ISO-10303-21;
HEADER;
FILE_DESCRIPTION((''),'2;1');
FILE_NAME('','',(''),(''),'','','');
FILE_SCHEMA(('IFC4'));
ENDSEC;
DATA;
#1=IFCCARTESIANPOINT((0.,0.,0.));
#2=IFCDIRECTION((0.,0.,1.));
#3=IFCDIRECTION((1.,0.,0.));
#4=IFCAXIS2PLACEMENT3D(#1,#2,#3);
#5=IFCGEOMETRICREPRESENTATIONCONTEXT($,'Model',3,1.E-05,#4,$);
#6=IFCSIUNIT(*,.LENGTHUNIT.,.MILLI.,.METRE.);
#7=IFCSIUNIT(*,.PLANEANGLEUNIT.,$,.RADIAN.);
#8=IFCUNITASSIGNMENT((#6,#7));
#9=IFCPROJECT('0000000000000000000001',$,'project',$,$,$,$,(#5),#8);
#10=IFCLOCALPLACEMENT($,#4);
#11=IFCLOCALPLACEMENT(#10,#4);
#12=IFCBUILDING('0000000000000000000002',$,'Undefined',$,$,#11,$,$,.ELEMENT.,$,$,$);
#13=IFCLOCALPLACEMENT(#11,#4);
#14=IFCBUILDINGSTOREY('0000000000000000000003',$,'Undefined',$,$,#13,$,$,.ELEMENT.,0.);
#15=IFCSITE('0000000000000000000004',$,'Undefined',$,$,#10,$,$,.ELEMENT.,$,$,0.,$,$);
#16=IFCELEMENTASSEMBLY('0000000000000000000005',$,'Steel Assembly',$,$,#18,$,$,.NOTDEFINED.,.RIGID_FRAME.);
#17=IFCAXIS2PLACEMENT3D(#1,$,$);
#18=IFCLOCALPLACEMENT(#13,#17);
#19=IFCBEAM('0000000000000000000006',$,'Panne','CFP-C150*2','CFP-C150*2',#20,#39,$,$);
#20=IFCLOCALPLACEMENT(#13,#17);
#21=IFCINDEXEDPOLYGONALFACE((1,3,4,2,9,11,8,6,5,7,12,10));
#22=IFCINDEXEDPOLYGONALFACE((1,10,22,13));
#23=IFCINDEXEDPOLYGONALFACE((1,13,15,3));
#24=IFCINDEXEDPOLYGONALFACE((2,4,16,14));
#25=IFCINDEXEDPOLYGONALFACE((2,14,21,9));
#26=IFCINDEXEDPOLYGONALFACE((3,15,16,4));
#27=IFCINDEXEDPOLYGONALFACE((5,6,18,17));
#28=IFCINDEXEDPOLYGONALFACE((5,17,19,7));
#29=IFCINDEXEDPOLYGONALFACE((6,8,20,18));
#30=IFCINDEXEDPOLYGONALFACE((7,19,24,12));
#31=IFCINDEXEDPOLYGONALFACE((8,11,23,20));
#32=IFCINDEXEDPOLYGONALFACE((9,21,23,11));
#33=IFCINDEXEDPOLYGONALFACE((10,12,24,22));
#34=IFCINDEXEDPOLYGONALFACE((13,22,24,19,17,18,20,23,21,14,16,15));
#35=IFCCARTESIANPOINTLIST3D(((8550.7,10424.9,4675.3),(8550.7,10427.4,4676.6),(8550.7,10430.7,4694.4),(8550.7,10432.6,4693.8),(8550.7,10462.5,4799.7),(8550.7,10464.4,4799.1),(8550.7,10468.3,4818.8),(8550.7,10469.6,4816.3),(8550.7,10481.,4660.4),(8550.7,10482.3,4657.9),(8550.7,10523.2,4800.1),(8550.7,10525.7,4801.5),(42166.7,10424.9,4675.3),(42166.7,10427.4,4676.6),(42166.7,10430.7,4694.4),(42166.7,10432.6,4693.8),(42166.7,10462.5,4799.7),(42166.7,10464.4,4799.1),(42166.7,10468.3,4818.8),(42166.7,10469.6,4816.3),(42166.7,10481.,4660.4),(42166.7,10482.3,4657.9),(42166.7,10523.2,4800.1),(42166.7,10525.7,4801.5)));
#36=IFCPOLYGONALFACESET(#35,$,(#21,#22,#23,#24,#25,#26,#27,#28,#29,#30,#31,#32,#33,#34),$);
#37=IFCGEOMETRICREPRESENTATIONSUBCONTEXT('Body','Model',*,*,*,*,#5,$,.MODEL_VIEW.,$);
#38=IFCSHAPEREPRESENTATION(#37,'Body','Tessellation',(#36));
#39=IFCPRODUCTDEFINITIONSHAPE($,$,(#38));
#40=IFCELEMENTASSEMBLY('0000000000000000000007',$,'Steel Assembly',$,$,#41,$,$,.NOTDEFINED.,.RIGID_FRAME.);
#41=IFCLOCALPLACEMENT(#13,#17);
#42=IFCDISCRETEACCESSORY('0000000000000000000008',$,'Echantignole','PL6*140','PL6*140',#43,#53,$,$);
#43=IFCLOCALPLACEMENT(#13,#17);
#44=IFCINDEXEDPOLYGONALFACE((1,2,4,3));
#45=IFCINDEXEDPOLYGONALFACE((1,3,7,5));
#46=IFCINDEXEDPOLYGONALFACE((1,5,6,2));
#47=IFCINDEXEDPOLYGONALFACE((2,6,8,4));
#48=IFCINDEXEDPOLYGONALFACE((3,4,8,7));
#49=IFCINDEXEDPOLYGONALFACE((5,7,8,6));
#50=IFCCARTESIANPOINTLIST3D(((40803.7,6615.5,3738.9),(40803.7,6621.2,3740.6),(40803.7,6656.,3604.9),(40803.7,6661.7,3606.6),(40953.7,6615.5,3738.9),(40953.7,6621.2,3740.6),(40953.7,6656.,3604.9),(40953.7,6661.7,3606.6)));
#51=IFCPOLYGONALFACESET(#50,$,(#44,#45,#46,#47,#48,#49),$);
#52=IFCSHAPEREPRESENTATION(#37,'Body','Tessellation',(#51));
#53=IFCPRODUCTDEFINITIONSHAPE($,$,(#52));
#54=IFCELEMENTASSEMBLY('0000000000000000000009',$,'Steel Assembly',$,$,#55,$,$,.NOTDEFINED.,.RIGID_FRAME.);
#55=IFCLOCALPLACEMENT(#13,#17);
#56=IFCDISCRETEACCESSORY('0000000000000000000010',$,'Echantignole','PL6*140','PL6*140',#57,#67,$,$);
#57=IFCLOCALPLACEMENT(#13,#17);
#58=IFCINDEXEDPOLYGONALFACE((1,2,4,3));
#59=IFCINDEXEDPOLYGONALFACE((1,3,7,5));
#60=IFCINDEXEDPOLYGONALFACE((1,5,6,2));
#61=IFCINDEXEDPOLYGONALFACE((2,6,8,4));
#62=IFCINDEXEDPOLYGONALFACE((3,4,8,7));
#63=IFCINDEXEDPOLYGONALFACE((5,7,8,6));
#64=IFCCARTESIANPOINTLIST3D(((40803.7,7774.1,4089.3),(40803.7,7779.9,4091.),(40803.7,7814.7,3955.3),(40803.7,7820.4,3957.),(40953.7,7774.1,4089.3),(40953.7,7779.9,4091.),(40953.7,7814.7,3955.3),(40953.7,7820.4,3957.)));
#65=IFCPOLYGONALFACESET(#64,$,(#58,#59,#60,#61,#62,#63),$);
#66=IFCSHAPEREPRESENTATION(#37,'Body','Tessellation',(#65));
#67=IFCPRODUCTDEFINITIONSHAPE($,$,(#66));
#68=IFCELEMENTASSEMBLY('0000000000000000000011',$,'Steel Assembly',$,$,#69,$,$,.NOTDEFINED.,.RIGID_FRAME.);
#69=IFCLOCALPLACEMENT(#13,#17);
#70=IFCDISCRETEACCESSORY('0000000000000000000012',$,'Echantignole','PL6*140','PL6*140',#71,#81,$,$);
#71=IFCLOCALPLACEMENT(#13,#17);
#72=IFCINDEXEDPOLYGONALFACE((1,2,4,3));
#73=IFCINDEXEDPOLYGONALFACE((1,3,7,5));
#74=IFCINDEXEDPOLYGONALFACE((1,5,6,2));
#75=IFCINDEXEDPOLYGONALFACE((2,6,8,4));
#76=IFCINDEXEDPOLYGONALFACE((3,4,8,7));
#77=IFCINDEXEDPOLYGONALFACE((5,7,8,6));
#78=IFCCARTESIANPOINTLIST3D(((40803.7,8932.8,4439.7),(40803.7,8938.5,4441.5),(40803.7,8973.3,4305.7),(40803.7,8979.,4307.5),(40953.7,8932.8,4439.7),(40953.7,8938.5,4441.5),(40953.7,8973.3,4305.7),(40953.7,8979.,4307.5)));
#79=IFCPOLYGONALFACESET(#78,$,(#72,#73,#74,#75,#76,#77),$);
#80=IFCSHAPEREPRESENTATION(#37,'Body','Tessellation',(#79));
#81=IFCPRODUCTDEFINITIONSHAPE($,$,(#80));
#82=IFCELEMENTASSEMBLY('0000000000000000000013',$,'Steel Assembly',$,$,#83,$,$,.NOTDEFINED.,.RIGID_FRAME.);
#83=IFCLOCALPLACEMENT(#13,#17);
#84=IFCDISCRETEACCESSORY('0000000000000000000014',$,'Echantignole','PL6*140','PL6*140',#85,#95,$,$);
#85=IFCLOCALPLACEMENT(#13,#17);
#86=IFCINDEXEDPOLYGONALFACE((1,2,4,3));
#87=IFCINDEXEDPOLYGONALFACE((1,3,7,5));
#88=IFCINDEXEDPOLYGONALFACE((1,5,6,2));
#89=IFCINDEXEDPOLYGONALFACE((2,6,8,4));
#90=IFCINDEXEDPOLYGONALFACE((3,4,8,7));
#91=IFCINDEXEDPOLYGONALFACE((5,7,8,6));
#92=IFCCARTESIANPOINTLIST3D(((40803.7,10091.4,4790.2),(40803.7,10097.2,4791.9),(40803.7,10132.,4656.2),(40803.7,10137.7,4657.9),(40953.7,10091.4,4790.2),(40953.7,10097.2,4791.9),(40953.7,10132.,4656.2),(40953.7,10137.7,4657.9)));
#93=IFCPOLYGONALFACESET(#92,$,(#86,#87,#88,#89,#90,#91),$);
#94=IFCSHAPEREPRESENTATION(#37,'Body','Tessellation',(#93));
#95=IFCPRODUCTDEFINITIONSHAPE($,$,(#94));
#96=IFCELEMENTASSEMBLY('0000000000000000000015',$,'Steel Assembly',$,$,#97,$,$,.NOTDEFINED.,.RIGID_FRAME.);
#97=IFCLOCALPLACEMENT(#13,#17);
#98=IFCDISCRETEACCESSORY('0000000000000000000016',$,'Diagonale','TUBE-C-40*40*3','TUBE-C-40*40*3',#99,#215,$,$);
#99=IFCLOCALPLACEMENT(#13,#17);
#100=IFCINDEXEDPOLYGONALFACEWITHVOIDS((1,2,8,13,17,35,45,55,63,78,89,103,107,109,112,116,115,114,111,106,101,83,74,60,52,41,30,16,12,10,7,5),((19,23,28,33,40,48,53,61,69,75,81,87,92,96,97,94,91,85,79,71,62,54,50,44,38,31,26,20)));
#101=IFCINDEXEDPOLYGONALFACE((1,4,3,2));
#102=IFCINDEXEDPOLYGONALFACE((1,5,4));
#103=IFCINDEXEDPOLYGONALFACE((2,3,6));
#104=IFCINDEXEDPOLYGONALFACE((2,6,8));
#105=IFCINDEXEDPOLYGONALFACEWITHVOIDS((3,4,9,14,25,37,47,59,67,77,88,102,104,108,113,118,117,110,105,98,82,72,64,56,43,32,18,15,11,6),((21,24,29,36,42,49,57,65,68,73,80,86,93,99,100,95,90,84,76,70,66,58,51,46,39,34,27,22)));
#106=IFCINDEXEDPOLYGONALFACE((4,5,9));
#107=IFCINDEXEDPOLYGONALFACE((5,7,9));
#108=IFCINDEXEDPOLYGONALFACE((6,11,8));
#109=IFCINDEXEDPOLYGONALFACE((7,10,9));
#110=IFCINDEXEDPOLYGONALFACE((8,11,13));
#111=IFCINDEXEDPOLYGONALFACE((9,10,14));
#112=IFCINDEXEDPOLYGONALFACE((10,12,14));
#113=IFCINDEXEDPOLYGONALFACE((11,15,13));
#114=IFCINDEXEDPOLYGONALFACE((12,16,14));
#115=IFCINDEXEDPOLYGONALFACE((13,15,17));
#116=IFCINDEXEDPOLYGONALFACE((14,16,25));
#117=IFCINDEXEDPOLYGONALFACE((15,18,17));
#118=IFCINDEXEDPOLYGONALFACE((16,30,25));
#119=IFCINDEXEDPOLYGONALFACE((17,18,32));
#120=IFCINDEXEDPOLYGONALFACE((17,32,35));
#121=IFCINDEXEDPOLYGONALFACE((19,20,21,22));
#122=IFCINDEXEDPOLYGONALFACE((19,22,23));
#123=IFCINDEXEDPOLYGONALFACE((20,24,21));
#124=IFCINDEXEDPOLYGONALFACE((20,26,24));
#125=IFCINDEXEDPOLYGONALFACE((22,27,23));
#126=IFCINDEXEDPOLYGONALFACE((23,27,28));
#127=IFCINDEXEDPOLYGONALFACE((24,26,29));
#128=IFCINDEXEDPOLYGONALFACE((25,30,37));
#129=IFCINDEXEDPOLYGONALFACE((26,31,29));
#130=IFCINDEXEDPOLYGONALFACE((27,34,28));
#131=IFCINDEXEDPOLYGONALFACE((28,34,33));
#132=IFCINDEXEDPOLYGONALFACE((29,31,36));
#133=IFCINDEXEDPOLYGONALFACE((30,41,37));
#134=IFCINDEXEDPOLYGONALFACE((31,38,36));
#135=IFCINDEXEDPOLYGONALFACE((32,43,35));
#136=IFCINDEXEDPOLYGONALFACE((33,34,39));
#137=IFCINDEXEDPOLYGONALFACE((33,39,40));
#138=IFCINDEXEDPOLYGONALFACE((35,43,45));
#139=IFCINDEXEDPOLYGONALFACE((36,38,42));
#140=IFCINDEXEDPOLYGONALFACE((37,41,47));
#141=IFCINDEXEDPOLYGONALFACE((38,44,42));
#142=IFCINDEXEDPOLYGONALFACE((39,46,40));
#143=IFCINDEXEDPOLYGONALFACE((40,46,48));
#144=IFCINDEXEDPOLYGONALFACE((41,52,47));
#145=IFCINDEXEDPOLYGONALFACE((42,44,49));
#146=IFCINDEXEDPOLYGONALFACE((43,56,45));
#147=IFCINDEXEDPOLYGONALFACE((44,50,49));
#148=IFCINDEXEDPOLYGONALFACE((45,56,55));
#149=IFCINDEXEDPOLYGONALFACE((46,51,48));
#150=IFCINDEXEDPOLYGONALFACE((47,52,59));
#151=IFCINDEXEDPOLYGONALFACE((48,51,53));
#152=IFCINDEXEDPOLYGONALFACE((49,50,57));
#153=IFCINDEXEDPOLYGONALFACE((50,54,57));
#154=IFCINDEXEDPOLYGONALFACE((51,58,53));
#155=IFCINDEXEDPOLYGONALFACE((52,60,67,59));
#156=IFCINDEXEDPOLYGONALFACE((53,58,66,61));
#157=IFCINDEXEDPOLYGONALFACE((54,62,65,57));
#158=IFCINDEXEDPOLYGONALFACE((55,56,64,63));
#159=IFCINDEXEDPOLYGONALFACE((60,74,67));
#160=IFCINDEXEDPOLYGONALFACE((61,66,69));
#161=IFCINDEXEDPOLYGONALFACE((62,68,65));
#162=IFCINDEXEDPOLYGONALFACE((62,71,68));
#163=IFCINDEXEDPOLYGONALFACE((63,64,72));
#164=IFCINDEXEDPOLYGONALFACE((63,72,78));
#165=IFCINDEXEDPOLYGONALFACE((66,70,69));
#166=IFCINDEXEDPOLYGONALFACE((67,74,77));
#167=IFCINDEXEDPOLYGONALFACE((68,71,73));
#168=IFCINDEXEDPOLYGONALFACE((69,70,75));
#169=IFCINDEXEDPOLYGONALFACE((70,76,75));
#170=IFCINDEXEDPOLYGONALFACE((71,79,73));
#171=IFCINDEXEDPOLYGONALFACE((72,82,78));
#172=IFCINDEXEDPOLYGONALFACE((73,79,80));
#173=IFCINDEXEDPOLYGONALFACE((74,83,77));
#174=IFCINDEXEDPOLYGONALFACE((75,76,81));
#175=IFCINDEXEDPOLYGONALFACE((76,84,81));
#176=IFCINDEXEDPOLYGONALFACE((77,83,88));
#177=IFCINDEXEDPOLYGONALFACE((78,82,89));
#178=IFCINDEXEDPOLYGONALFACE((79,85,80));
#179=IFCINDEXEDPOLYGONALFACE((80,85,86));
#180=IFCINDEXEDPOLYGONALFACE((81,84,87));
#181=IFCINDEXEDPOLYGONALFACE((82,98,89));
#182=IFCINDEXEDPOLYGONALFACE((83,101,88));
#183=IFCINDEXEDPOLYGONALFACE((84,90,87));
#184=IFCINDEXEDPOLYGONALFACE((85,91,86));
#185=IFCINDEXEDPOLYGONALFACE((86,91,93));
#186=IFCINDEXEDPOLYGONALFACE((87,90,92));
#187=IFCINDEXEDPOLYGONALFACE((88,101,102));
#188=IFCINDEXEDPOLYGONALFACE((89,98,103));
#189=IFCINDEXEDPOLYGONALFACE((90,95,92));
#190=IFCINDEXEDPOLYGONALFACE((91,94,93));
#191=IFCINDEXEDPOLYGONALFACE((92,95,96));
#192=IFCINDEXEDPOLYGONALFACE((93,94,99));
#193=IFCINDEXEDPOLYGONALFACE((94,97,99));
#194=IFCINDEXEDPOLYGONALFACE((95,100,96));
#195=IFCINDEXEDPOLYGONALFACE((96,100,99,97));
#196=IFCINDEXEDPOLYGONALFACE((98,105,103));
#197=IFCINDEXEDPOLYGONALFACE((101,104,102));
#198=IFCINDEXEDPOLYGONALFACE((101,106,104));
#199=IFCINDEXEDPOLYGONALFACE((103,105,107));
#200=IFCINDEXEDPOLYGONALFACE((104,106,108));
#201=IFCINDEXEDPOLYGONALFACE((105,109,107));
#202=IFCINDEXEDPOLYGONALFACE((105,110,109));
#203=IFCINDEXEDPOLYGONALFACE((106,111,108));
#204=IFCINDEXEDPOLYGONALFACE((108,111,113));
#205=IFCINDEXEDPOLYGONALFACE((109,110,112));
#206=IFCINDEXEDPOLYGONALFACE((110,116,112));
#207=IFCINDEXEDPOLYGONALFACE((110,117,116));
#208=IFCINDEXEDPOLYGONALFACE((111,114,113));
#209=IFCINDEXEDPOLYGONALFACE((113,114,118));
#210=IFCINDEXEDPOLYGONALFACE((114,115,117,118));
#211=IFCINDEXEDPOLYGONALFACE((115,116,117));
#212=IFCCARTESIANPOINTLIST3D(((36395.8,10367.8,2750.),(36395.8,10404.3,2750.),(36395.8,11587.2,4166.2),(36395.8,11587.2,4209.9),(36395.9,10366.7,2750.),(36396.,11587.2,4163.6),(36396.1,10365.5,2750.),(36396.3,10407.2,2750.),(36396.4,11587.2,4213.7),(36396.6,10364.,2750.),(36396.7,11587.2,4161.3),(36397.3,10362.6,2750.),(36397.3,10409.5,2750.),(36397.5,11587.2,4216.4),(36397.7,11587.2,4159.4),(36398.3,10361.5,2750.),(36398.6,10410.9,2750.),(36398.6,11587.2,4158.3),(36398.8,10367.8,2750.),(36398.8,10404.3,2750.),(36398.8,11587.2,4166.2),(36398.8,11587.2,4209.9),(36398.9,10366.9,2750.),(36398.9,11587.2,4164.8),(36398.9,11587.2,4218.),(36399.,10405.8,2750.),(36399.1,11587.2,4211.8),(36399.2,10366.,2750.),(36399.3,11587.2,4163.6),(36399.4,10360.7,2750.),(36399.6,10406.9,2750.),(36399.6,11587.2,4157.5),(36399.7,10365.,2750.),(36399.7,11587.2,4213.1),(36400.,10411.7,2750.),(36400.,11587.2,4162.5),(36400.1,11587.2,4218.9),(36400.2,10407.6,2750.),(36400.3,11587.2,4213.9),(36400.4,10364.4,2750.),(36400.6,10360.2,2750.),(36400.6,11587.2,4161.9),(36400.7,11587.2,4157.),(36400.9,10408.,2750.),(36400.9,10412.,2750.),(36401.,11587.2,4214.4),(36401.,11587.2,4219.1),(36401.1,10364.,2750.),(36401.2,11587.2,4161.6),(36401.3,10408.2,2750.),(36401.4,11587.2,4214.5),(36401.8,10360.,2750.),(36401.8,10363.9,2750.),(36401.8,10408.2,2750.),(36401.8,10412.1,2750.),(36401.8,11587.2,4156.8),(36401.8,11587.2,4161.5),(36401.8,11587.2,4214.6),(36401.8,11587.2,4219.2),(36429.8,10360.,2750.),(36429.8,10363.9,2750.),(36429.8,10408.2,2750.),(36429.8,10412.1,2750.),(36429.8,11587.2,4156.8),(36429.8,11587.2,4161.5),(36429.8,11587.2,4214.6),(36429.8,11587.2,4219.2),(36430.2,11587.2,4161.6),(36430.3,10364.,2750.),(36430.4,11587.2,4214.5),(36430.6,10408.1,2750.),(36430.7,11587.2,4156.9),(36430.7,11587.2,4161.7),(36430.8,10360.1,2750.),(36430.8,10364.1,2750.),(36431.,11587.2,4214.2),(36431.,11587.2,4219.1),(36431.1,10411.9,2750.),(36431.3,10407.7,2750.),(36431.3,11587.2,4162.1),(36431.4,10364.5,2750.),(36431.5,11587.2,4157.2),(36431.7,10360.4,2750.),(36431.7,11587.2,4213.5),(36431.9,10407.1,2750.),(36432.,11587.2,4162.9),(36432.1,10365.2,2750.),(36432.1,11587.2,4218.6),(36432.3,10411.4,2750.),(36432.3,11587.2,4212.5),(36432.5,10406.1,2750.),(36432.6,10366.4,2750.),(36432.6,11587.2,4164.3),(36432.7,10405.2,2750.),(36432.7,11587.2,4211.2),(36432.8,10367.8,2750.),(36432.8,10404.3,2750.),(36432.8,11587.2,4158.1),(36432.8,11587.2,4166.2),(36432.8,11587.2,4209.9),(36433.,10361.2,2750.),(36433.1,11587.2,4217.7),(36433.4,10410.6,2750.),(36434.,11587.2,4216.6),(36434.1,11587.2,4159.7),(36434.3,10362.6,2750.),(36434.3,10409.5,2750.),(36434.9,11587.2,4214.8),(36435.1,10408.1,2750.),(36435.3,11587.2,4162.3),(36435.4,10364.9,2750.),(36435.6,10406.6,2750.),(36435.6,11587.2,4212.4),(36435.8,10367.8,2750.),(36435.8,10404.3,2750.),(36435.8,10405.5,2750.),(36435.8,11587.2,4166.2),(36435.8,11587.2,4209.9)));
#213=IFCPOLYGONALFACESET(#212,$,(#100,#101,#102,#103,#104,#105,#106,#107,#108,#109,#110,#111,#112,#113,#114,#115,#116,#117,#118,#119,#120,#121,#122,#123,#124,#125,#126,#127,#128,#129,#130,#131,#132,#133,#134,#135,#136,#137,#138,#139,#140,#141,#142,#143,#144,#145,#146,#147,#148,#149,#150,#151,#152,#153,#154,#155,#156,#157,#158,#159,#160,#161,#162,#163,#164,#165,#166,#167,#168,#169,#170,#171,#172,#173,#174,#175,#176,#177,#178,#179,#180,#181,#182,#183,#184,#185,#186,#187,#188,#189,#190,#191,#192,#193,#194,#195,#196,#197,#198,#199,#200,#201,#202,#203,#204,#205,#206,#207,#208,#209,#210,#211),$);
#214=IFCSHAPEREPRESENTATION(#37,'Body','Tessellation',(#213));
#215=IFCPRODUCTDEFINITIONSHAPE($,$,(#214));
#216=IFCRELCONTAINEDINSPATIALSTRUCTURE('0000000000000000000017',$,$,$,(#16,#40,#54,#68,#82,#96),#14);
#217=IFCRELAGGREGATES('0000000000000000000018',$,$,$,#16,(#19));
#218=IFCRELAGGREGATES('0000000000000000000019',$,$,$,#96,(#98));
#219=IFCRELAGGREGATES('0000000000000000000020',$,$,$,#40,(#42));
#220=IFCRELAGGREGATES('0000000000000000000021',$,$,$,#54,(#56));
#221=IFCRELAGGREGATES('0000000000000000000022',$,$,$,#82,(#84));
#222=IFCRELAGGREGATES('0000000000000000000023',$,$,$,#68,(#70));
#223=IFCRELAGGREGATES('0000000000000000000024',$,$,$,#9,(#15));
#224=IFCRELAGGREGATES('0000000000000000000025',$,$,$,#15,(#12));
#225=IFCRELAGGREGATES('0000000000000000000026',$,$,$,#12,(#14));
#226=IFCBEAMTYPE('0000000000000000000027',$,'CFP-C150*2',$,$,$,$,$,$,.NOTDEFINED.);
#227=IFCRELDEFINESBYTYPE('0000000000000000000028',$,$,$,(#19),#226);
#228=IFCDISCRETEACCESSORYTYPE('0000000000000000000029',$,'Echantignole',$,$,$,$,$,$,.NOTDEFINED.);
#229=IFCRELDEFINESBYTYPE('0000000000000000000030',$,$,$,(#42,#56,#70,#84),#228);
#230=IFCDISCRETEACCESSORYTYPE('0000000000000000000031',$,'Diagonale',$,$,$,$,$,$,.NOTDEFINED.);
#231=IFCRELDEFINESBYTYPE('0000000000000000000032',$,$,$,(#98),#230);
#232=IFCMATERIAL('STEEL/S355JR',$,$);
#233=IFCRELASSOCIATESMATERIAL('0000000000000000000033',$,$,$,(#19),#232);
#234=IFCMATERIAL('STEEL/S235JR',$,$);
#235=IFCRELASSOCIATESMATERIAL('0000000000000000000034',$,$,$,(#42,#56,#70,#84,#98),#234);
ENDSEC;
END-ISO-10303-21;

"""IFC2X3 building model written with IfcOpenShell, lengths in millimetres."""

from ifc_helpers import new_model, si_unit, frame, origin_with_axes, origin_2d_with_axis, place, context, subcontext, project, spatial, polyline, hollow_rectangle, c_section, outline, extrude, clip, halfspace, material, type_object, element, aggregate, save


model = new_model("IFC2X3")

# Units and contexts
model_context = context("Model", 3, precision=1e-05, world=origin_with_axes())
body_context = subcontext(model_context, "Body", "Model", "MODEL_VIEW")
ifc_project = project(units=[si_unit("LENGTHUNIT", "METRE", prefix="MILLI"), si_unit("PLANEANGLEUNIT", "RADIAN")], contexts=[model_context])

# Site, building, storey
site_placement = place(None, origin_with_axes())
site = spatial("IfcSite", under=ifc_project, at=site_placement, Name="Undefined", CompositionType="ELEMENT", RefElevation=0.0)
building_placement = place(site_placement, origin_with_axes())
building = spatial("IfcBuilding", under=site, at=building_placement, Name="Undefined", CompositionType="ELEMENT")
storey_placement = place(building_placement, origin_with_axes())
storey = spatial("IfcBuildingStorey", under=building, at=storey_placement, Name="Undefined", CompositionType="ELEMENT", Elevation=0.0)

# Element assembly, beam
assembly_1_placement = place(storey_placement, origin_with_axes())
assembly_1 = element("IfcElementAssembly", 1, at=assembly_1_placement, inside=storey, Name="Steel Assembly", AssemblyPlace="NOTDEFINED", PredefinedType="RIGID_FRAME")
ifc_material_1 = material(Name="STEEL/S355JR")
beam_type = type_object("IfcBeamType", Name="CFP-C150*2", PredefinedType="NOTDEFINED")
beam_placement = place(assembly_1_placement, frame((42166.7, 10475.3, 4738.4), z_axis=(0.0, -0.289497, -0.957179), x_axis=(-1.0, 0.0, 0.0)))
beam = element("IfcBeam", 2, at=beam_placement, type_object=beam_type, material=ifc_material_1, Name="Panne", Description="CFP-C150*2", ObjectType="CFP-C150*2", context=body_context, shape_type="SweptSolid", body=[
    extrude(c_section(Depth=150.0, Width=60.0, WallThickness=2.0, Girth=20.0, at=origin_2d_with_axis()), frame((33616.0, 0.0, 0.0), z_axis=(-1.0, 0.0, 0.0), x_axis=(0.0, -1.0, 0.0)), (0.0, 0.0, 1.0), 33616.0),
])
aggregate(assembly_1, [beam])

# Element assemblies, discrete accessories
assembly_2_placement = place(storey_placement, origin_with_axes())
assembly_2 = element("IfcElementAssembly", 3, at=assembly_2_placement, inside=storey, Name="Steel Assembly", AssemblyPlace="NOTDEFINED", PredefinedType="RIGID_FRAME")
ifc_material_2 = material(Name="STEEL/S235JR")
discrete_accessory_type_1 = type_object("IfcDiscreteAccessoryType", Name="Echantignole")
discrete_accessory_1_placement = place(assembly_2_placement, frame((40803.7, 6638.6, 3672.7), z_axis=(0.0, -0.957179, -0.289497), x_axis=(1.0, 0.0, 0.0)))
discrete_accessory_1 = element("IfcDiscreteAccessory", 4, at=discrete_accessory_1_placement, type_object=discrete_accessory_type_1, material=ifc_material_2, Name="Echantignole", Description="PL6*140", ObjectType="PL6*140", context=body_context, shape_type="SweptSolid", body=[
    extrude(outline(polyline([(150.0, 70.0), (150.0, -70.0), (0.0, -70.0), (0.0, 70.0), (150.0, 70.0)])), frame((0.0, 0.0, -3.0), z_axis=(0.0, 0.0, 1.0), x_axis=(1.0, 0.0, 0.0)), (0.0, 0.0, 1.0), 6.0),
])
assembly_3_placement = place(storey_placement, origin_with_axes())
assembly_3 = element("IfcElementAssembly", 5, at=assembly_3_placement, inside=storey, Name="Steel Assembly", AssemblyPlace="NOTDEFINED", PredefinedType="RIGID_FRAME")
discrete_accessory_2_placement = place(assembly_3_placement, frame((40803.7, 7797.3, 4023.2), z_axis=(0.0, -0.957179, -0.289497), x_axis=(1.0, 0.0, 0.0)))
discrete_accessory_2 = element("IfcDiscreteAccessory", 6, at=discrete_accessory_2_placement, type_object=discrete_accessory_type_1, material=ifc_material_2, Name="Echantignole", Description="PL6*140", ObjectType="PL6*140", context=body_context, shape_type="SweptSolid", body=[
    extrude(outline(polyline([(150.0, 70.0), (150.0, -70.0), (0.0, -70.0), (0.0, 70.0), (150.0, 70.0)])), frame((0.0, 0.0, -3.0), z_axis=(0.0, 0.0, 1.0), x_axis=(1.0, 0.0, 0.0)), (0.0, 0.0, 1.0), 6.0),
])
assembly_4_placement = place(storey_placement, origin_with_axes())
assembly_4 = element("IfcElementAssembly", 7, at=assembly_4_placement, inside=storey, Name="Steel Assembly", AssemblyPlace="NOTDEFINED", PredefinedType="RIGID_FRAME")
discrete_accessory_3_placement = place(assembly_4_placement, frame((40803.7, 8955.9, 4373.6), z_axis=(0.0, -0.957179, -0.289497), x_axis=(1.0, 0.0, 0.0)))
discrete_accessory_3 = element("IfcDiscreteAccessory", 8, at=discrete_accessory_3_placement, type_object=discrete_accessory_type_1, material=ifc_material_2, Name="Echantignole", Description="PL6*140", ObjectType="PL6*140", context=body_context, shape_type="SweptSolid", body=[
    extrude(outline(polyline([(150.0, 70.0), (150.0, -70.0), (0.0, -70.0), (0.0, 70.0), (150.0, 70.0)])), frame((0.0, 0.0, -3.0), z_axis=(0.0, 0.0, 1.0), x_axis=(1.0, 0.0, 0.0)), (0.0, 0.0, 1.0), 6.0),
])
assembly_5_placement = place(storey_placement, origin_with_axes())
assembly_5 = element("IfcElementAssembly", 9, at=assembly_5_placement, inside=storey, Name="Steel Assembly", AssemblyPlace="NOTDEFINED", PredefinedType="RIGID_FRAME")
discrete_accessory_4_placement = place(assembly_5_placement, frame((40803.7, 10114.6, 4724.0), z_axis=(0.0, -0.957179, -0.289497), x_axis=(1.0, 0.0, 0.0)))
discrete_accessory_4 = element("IfcDiscreteAccessory", 10, at=discrete_accessory_4_placement, type_object=discrete_accessory_type_1, material=ifc_material_2, Name="Echantignole", Description="PL6*140", ObjectType="PL6*140", context=body_context, shape_type="SweptSolid", body=[
    extrude(outline(polyline([(150.0, 70.0), (150.0, -70.0), (0.0, -70.0), (0.0, 70.0), (150.0, 70.0)])), frame((0.0, 0.0, -3.0), z_axis=(0.0, 0.0, 1.0), x_axis=(1.0, 0.0, 0.0)), (0.0, 0.0, 1.0), 6.0),
])

# Element assembly, discrete accessory
assembly_6_placement = place(storey_placement, origin_with_axes())
assembly_6 = element("IfcElementAssembly", 11, at=assembly_6_placement, inside=storey, Name="Steel Assembly", AssemblyPlace="NOTDEFINED", PredefinedType="RIGID_FRAME")
discrete_accessory_type_2 = type_object("IfcDiscreteAccessoryType", Name="Diagonale")
discrete_accessory_5_placement = place(assembly_6_placement, frame((36415.8, 10375.3, 2737.2), z_axis=(0.0, -0.767483, 0.64107), x_axis=(0.0, 0.64107, 0.767483)))
discrete_accessory_5 = element("IfcDiscreteAccessory", 12, at=discrete_accessory_5_placement, type_object=discrete_accessory_type_2, material=ifc_material_2, Name="Diagonale", Description="TUBE-C-40*40*3", ObjectType="TUBE-C-40*40*3", context=body_context, shape_type="Clipping", body=[
    clip(clip(extrude(hollow_rectangle(XDim=40.0, YDim=40.0, WallThickness=3.0, InnerFilletRadius=3.0, OuterFilletRadius=6.0, at=origin_2d_with_axis()), frame((1931.5, 0.0, 0.0), z_axis=(-1.0, 0.0, 0.0), x_axis=(0.0, -1.0, 0.0)), (0.0, 0.0, 1.0), 1955.8), halfspace(frame((1843.1, 0.0, -39.5), z_axis=(0.64107, 0.0, -0.767483), x_axis=(0.0, -1.0, 0.0)), False)), halfspace(frame((17.2, 0.0, -0.6), z_axis=(-0.767483, 0.0, -0.64107), x_axis=(0.0, -1.0, 0.0)), False)),
])
aggregate(assembly_6, [discrete_accessory_5])

aggregate(assembly_2, [discrete_accessory_1])
aggregate(assembly_3, [discrete_accessory_2])
aggregate(assembly_5, [discrete_accessory_4])
aggregate(assembly_4, [discrete_accessory_3])

save(model, "model.ifc")
